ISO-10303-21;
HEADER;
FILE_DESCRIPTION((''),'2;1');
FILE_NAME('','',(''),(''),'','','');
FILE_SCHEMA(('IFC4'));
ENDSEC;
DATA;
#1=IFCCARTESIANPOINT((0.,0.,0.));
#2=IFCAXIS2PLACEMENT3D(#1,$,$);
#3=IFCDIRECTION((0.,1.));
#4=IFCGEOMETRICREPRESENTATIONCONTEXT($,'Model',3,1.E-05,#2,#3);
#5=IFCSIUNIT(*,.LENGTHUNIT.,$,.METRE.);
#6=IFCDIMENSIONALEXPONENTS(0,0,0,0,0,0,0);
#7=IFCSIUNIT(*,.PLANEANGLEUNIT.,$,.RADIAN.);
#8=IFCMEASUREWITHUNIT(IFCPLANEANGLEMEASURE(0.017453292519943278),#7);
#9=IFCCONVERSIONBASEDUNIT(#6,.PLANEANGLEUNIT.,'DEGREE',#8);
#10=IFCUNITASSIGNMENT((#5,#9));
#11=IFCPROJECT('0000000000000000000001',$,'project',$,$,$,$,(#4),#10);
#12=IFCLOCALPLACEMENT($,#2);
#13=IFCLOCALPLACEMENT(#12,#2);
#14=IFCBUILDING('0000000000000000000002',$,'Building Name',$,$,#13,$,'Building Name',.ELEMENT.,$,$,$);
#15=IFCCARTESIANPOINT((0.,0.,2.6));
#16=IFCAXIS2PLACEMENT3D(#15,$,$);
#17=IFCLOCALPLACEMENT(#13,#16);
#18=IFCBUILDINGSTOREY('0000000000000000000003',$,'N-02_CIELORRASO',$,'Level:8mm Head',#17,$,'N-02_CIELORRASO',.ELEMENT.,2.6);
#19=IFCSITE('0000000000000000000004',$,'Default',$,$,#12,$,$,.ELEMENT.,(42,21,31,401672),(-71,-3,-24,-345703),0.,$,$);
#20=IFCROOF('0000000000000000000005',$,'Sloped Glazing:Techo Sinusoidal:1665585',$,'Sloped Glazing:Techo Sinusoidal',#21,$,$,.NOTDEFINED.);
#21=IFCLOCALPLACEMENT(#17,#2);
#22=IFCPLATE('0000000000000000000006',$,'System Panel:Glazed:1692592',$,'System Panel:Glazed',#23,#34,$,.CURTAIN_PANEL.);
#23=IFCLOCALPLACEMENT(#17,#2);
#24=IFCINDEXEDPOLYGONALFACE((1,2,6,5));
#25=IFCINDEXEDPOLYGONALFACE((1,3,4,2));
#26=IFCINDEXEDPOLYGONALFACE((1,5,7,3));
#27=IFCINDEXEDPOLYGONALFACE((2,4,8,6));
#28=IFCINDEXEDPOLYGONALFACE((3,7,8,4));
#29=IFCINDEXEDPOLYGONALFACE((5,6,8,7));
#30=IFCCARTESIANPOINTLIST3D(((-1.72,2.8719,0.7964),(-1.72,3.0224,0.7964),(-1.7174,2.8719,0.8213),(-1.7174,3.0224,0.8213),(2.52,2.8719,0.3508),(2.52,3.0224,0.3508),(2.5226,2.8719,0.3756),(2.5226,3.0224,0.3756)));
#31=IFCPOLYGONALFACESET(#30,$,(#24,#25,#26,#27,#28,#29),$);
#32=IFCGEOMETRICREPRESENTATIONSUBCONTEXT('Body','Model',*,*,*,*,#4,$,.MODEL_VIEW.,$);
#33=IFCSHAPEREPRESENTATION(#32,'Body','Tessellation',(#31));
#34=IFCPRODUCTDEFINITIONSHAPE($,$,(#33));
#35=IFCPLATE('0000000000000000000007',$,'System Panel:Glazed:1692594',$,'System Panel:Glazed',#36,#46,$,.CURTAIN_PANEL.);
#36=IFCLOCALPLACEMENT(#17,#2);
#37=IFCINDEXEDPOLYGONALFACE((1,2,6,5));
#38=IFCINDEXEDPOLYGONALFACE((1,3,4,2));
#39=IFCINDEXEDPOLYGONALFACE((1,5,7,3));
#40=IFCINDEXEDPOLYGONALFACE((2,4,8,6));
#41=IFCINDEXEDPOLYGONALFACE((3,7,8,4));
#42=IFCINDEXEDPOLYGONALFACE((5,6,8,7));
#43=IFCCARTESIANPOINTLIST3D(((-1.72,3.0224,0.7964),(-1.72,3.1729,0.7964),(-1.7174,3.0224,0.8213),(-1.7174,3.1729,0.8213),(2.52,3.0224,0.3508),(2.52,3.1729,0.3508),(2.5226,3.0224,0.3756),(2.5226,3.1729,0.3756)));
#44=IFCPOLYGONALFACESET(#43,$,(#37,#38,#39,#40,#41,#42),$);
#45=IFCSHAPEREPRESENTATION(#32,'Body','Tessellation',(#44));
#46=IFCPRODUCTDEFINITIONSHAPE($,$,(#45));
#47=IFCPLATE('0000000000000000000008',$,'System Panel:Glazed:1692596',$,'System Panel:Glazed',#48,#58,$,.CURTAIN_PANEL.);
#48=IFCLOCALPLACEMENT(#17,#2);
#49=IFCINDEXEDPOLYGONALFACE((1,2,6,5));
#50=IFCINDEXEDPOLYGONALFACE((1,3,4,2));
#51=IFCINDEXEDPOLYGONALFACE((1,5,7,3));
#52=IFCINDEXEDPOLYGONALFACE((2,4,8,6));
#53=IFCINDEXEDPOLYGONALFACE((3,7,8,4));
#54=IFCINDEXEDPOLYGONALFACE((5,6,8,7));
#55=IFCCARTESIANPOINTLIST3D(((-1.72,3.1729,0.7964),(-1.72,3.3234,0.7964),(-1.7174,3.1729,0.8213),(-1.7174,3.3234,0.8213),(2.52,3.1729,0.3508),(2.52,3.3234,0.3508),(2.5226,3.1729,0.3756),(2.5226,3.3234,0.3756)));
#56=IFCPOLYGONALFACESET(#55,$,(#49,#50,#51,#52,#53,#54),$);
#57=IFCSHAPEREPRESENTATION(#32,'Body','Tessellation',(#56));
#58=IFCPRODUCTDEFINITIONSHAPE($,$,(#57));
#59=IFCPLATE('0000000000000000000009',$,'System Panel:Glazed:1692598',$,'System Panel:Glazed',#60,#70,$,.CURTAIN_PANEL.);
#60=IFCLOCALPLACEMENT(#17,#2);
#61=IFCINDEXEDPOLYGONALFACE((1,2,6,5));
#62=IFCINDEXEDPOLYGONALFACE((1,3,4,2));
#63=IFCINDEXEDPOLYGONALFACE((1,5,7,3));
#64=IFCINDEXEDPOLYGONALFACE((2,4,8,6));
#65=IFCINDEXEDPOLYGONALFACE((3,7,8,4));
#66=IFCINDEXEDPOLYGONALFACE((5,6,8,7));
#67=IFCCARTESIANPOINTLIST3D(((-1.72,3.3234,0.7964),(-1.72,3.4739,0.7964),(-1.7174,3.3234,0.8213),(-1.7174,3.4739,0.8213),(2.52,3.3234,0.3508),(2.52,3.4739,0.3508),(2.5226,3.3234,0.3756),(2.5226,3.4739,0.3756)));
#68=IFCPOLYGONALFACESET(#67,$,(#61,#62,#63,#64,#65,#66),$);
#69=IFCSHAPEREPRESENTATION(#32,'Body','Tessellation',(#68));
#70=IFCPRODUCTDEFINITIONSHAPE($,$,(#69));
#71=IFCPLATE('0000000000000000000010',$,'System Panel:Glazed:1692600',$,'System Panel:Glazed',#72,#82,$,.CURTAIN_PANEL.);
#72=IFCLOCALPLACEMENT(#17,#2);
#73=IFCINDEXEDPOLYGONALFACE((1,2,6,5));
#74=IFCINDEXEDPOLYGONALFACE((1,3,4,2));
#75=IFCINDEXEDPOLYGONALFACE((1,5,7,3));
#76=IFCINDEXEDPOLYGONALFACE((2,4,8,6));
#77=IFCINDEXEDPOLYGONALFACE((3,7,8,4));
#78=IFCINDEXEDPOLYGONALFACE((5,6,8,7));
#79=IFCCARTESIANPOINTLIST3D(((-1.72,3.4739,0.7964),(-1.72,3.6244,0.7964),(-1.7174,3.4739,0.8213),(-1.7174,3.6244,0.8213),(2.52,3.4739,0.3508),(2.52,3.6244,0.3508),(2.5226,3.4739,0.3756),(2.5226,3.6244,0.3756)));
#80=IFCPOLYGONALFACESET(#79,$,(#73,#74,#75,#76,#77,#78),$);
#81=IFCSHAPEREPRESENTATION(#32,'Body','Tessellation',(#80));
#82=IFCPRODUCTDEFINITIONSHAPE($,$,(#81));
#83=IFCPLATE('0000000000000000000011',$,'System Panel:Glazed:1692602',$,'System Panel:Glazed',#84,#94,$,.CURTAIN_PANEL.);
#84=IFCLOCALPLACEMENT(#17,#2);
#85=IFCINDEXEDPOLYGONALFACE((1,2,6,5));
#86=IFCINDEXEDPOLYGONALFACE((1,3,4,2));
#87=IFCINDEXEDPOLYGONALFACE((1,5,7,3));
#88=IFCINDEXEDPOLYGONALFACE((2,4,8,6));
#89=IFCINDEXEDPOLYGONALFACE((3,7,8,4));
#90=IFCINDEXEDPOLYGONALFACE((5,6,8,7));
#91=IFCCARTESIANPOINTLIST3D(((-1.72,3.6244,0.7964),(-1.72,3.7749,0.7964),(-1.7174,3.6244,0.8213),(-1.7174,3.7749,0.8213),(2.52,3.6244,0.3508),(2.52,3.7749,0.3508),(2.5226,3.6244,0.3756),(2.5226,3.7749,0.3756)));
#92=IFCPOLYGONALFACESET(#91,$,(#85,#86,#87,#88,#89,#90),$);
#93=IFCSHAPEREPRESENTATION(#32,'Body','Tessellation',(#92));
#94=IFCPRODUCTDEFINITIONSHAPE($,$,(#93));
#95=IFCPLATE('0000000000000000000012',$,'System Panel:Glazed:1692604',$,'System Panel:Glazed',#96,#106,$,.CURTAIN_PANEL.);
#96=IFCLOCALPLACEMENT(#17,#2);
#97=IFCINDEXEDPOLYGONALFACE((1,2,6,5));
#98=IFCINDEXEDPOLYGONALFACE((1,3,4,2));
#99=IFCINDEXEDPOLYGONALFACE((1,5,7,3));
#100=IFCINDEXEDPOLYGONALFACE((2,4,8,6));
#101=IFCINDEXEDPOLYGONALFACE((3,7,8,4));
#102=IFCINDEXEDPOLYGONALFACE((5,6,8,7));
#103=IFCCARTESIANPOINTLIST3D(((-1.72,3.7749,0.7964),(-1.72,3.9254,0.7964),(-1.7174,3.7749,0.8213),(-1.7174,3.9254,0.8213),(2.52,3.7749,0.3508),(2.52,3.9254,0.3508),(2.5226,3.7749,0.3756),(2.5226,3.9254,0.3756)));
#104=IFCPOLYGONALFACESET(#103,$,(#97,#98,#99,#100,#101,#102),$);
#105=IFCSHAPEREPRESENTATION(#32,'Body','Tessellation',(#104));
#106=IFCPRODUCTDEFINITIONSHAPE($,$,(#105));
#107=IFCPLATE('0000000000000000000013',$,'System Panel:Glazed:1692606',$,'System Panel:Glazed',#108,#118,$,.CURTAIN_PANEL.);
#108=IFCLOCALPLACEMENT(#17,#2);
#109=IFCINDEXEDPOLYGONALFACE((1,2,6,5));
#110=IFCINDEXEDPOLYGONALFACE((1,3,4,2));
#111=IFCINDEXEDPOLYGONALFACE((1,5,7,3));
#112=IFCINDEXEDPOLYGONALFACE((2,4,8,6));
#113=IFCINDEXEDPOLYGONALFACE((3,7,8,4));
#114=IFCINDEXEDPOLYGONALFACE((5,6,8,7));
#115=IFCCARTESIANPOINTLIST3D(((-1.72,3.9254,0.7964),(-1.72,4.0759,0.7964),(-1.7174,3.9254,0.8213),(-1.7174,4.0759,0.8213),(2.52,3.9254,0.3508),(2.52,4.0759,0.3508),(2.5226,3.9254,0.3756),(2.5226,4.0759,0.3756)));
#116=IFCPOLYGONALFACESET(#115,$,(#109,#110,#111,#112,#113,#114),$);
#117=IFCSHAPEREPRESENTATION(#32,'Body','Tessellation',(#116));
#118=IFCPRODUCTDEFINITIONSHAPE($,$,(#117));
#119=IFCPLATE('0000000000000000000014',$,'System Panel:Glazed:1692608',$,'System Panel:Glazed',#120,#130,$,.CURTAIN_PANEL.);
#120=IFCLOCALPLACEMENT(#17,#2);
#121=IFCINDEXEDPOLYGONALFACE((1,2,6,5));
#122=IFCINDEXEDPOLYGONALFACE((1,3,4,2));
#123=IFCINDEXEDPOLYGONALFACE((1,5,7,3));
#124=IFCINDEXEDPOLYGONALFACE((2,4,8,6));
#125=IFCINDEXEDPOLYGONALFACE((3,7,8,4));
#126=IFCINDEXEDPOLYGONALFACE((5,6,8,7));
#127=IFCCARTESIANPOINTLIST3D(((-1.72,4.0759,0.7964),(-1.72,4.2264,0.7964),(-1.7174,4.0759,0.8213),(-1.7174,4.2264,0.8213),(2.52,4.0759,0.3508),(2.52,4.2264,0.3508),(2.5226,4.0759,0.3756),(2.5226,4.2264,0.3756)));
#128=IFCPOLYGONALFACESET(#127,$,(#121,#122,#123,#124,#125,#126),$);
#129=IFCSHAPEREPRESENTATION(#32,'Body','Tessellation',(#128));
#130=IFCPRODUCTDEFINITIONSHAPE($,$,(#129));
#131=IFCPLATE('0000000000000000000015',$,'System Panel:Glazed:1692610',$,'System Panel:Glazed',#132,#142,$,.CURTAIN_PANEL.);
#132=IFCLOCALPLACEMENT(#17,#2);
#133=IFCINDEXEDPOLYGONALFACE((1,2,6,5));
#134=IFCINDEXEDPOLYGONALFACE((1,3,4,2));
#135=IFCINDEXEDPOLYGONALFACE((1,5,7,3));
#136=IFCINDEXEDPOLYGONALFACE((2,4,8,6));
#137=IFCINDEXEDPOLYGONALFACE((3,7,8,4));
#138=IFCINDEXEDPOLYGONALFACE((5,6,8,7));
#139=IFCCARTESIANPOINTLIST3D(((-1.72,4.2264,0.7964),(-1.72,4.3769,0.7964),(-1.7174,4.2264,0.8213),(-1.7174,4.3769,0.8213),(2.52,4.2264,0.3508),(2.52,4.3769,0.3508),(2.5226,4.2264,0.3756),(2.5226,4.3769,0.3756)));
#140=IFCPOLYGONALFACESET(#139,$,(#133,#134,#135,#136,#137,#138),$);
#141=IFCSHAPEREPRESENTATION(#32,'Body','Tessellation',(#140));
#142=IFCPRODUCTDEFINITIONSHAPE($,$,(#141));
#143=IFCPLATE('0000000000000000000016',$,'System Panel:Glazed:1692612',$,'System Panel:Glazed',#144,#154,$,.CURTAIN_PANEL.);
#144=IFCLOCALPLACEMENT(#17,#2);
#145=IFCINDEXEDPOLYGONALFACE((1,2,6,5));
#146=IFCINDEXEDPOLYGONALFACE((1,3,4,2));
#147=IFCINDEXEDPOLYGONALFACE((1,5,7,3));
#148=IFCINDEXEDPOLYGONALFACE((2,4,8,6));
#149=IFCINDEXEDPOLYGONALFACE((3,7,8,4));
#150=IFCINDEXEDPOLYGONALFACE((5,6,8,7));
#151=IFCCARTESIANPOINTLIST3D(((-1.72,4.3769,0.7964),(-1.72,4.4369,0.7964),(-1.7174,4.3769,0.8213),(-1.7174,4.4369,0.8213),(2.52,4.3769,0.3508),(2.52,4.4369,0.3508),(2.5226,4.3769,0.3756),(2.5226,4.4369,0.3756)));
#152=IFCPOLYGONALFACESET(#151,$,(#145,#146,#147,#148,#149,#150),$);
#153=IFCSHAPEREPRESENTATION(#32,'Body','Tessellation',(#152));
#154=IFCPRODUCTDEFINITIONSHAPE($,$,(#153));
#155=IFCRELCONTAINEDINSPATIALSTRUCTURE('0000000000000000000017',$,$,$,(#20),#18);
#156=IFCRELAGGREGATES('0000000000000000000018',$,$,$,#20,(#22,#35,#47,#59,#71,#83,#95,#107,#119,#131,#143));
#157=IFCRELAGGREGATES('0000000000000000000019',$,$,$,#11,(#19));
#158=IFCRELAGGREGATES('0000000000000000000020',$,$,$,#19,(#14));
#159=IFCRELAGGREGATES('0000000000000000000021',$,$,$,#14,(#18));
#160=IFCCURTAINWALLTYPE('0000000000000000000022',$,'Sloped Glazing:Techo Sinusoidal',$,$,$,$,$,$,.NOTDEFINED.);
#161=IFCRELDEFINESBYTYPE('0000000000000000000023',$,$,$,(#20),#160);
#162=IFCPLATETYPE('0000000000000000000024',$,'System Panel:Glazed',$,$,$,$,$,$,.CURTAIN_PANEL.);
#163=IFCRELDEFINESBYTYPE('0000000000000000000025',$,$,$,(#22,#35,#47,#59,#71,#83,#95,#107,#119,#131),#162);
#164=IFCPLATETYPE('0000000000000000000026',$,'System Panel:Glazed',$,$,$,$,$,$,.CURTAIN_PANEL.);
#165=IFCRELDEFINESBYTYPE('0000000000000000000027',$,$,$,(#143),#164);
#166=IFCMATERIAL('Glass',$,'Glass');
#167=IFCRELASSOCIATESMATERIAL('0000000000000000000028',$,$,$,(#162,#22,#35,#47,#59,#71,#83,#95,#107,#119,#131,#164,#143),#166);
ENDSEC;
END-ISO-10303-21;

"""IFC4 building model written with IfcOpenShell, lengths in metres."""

from ifc_helpers import new_model, entity, si_unit, converted_unit, direction, frame, origin, place, context, subcontext, project, spatial, indexed_curve, outline, extrude, source, transform, mapped, material, type_object, type_shapes, element, aggregate, save


model = new_model("IFC4")

# Units and contexts
model_context = context("Model", 3, precision=1e-05, world=origin(), true_north=direction((0.0, 1.0)))
body_context = subcontext(model_context, "Body", "Model", "MODEL_VIEW")
ifc_project = project(units=[si_unit("LENGTHUNIT", "METRE"), converted_unit("PLANEANGLEUNIT", "DEGREE", entity("IfcPlaneAngleMeasure", 0.017453292519943278), si_unit("PLANEANGLEUNIT", "RADIAN"), dimensions=[0, 0, 0, 0, 0, 0, 0])], contexts=[model_context])

# Site, building, storey
site_placement = place(None, origin())
site = spatial("IfcSite", under=ifc_project, at=site_placement, Name="Default", CompositionType="ELEMENT", RefLatitude=(42, 21, 31, 401672), RefLongitude=(-71, -3, -24, -345703), RefElevation=0.0)
building_placement = place(site_placement, origin())
building = spatial("IfcBuilding", under=site, at=building_placement, Name="Building Name", LongName="Building Name", CompositionType="ELEMENT")
storey_placement = place(building_placement, frame((0.0, 0.0, 2.6)))
storey = spatial("IfcBuildingStorey", under=building, at=storey_placement, Name="N-02_CIELORRASO", ObjectType="Level:8mm Head", LongName="N-02_CIELORRASO", CompositionType="ELEMENT", Elevation=2.6)

# Roof, plates
curtain_wall_type = type_object("IfcCurtainWallType", Name="Sloped Glazing:Techo Sinusoidal", PredefinedType="NOTDEFINED")
roof_placement = place(storey_placement, frame((0.0, 0.0, -2.6)))
roof = element("IfcRoof", 1, at=roof_placement, inside=storey, type_object=curtain_wall_type, Name="Sloped Glazing:Techo Sinusoidal:1665585", ObjectType="Sloped Glazing:Techo Sinusoidal", PredefinedType="NOTDEFINED")
ifc_material_1 = material(Name="Glass", Category="Glass")
plate_type_1 = type_object("IfcPlateType", Name="System Panel:Glazed", PredefinedType="CURTAIN_PANEL", material=ifc_material_1)
shared_shape_1 = source(origin(), body_context, "Body", "SweptSolid", [
    extrude(outline(indexed_curve([(-0.0125, -0.0752), (0.0125, -0.0752), (0.0125, 0.0752), (-0.0125, 0.0752), (-0.0125, -0.0752)], self_intersect=False)), frame((0.0, 0.037, 0.0), z_axis=(0.0, 0.0, 1.0), x_axis=(0.0, 1.0, 0.0)), (0.0, 0.0, 1.0), 4.2634),
])
type_shapes(plate_type_1, [shared_shape_1])
plate_1_placement = place(roof_placement, frame((2.5252, 2.9471, 3.0), z_axis=(-0.994522, 0.0, 0.104528), x_axis=(0.0, 1.0, 0.0)))
plate_1 = element("IfcPlate", 2, at=plate_1_placement, type_object=plate_type_1, material=ifc_material_1, Name="System Panel:Glazed:1692592", ObjectType="System Panel:Glazed", PredefinedType="CURTAIN_PANEL", context=body_context, shape_type="MappedRepresentation", body=[
    mapped(shared_shape_1, transform((0.0, 0.0, 0.0), scale=1.0)),
])
plate_2_placement = place(roof_placement, frame((2.5252, 3.0976, 3.0), z_axis=(-0.994522, 0.0, 0.104528), x_axis=(0.0, 1.0, 0.0)))
plate_2 = element("IfcPlate", 3, at=plate_2_placement, type_object=plate_type_1, material=ifc_material_1, Name="System Panel:Glazed:1692594", ObjectType="System Panel:Glazed", PredefinedType="CURTAIN_PANEL", context=body_context, shape_type="MappedRepresentation", body=[
    mapped(shared_shape_1, transform((0.0, 0.0, 0.0), scale=1.0)),
])
plate_3_placement = place(roof_placement, frame((2.5252, 3.2481, 3.0), z_axis=(-0.994522, 0.0, 0.104528), x_axis=(0.0, 1.0, 0.0)))
plate_3 = element("IfcPlate", 4, at=plate_3_placement, type_object=plate_type_1, material=ifc_material_1, Name="System Panel:Glazed:1692596", ObjectType="System Panel:Glazed", PredefinedType="CURTAIN_PANEL", context=body_context, shape_type="MappedRepresentation", body=[
    mapped(shared_shape_1, transform((0.0, 0.0, 0.0), scale=1.0)),
])
plate_4_placement = place(roof_placement, frame((2.5252, 3.3986, 3.0), z_axis=(-0.994522, 0.0, 0.104528), x_axis=(0.0, 1.0, 0.0)))
plate_4 = element("IfcPlate", 5, at=plate_4_placement, type_object=plate_type_1, material=ifc_material_1, Name="System Panel:Glazed:1692598", ObjectType="System Panel:Glazed", PredefinedType="CURTAIN_PANEL", context=body_context, shape_type="MappedRepresentation", body=[
    mapped(shared_shape_1, transform((0.0, 0.0, 0.0), scale=1.0)),
])
plate_5_placement = place(roof_placement, frame((2.5252, 3.5491, 3.0), z_axis=(-0.994522, 0.0, 0.104528), x_axis=(0.0, 1.0, 0.0)))
plate_5 = element("IfcPlate", 6, at=plate_5_placement, type_object=plate_type_1, material=ifc_material_1, Name="System Panel:Glazed:1692600", ObjectType="System Panel:Glazed", PredefinedType="CURTAIN_PANEL", context=body_context, shape_type="MappedRepresentation", body=[
    mapped(shared_shape_1, transform((0.0, 0.0, 0.0), scale=1.0)),
])
plate_6_placement = place(roof_placement, frame((2.5252, 3.6996, 3.0), z_axis=(-0.994522, 0.0, 0.104528), x_axis=(0.0, 1.0, 0.0)))
plate_6 = element("IfcPlate", 7, at=plate_6_placement, type_object=plate_type_1, material=ifc_material_1, Name="System Panel:Glazed:1692602", ObjectType="System Panel:Glazed", PredefinedType="CURTAIN_PANEL", context=body_context, shape_type="MappedRepresentation", body=[
    mapped(shared_shape_1, transform((0.0, 0.0, 0.0), scale=1.0)),
])
plate_7_placement = place(roof_placement, frame((2.5252, 3.8501, 3.0), z_axis=(-0.994522, 0.0, 0.104528), x_axis=(0.0, 1.0, 0.0)))
plate_7 = element("IfcPlate", 8, at=plate_7_placement, type_object=plate_type_1, material=ifc_material_1, Name="System Panel:Glazed:1692604", ObjectType="System Panel:Glazed", PredefinedType="CURTAIN_PANEL", context=body_context, shape_type="MappedRepresentation", body=[
    mapped(shared_shape_1, transform((0.0, 0.0, 0.0), scale=1.0)),
])
plate_8_placement = place(roof_placement, frame((2.5252, 4.0006, 3.0), z_axis=(-0.994522, 0.0, 0.104528), x_axis=(0.0, 1.0, 0.0)))
plate_8 = element("IfcPlate", 9, at=plate_8_placement, type_object=plate_type_1, material=ifc_material_1, Name="System Panel:Glazed:1692606", ObjectType="System Panel:Glazed", PredefinedType="CURTAIN_PANEL", context=body_context, shape_type="MappedRepresentation", body=[
    mapped(shared_shape_1, transform((0.0, 0.0, 0.0), scale=1.0)),
])
plate_9_placement = place(roof_placement, frame((2.5252, 4.1511, 3.0), z_axis=(-0.994522, 0.0, 0.104528), x_axis=(0.0, 1.0, 0.0)))
plate_9 = element("IfcPlate", 10, at=plate_9_placement, type_object=plate_type_1, material=ifc_material_1, Name="System Panel:Glazed:1692608", ObjectType="System Panel:Glazed", PredefinedType="CURTAIN_PANEL", context=body_context, shape_type="MappedRepresentation", body=[
    mapped(shared_shape_1, transform((0.0, 0.0, 0.0), scale=1.0)),
])
plate_10_placement = place(roof_placement, frame((2.5252, 4.3016, 3.0), z_axis=(-0.994522, 0.0, 0.104528), x_axis=(0.0, 1.0, 0.0)))
plate_10 = element("IfcPlate", 11, at=plate_10_placement, type_object=plate_type_1, material=ifc_material_1, Name="System Panel:Glazed:1692610", ObjectType="System Panel:Glazed", PredefinedType="CURTAIN_PANEL", context=body_context, shape_type="MappedRepresentation", body=[
    mapped(shared_shape_1, transform((0.0, 0.0, 0.0), scale=1.0)),
])
plate_type_2 = type_object("IfcPlateType", Name="System Panel:Glazed", PredefinedType="CURTAIN_PANEL", material=ifc_material_1)
shared_shape_2 = source(origin(), body_context, "Body", "SweptSolid", [
    extrude(outline(indexed_curve([(-0.0125, -0.03), (0.0125, -0.03), (0.0125, 0.03), (-0.0125, 0.03), (-0.0125, -0.03)], self_intersect=False)), frame((0.0, 0.037, 0.0), z_axis=(0.0, 0.0, 1.0), x_axis=(0.0, 1.0, 0.0)), (0.0, 0.0, 1.0), 4.2634),
])
type_shapes(plate_type_2, [shared_shape_2])
plate_11_placement = place(roof_placement, frame((2.5252, 4.4069, 3.0), z_axis=(-0.994522, 0.0, 0.104528), x_axis=(0.0, 1.0, 0.0)))
plate_11 = element("IfcPlate", 12, at=plate_11_placement, type_object=plate_type_2, material=ifc_material_1, Name="System Panel:Glazed:1692612", ObjectType="System Panel:Glazed", PredefinedType="CURTAIN_PANEL", context=body_context, shape_type="MappedRepresentation", body=[
    mapped(shared_shape_2, transform((0.0, 0.0, 0.0), scale=1.0)),
])
aggregate(roof, [plate_1, plate_2, plate_3, plate_4, plate_5, plate_6, plate_7, plate_8, plate_9, plate_10, plate_11])

save(model, "model.ifc")
